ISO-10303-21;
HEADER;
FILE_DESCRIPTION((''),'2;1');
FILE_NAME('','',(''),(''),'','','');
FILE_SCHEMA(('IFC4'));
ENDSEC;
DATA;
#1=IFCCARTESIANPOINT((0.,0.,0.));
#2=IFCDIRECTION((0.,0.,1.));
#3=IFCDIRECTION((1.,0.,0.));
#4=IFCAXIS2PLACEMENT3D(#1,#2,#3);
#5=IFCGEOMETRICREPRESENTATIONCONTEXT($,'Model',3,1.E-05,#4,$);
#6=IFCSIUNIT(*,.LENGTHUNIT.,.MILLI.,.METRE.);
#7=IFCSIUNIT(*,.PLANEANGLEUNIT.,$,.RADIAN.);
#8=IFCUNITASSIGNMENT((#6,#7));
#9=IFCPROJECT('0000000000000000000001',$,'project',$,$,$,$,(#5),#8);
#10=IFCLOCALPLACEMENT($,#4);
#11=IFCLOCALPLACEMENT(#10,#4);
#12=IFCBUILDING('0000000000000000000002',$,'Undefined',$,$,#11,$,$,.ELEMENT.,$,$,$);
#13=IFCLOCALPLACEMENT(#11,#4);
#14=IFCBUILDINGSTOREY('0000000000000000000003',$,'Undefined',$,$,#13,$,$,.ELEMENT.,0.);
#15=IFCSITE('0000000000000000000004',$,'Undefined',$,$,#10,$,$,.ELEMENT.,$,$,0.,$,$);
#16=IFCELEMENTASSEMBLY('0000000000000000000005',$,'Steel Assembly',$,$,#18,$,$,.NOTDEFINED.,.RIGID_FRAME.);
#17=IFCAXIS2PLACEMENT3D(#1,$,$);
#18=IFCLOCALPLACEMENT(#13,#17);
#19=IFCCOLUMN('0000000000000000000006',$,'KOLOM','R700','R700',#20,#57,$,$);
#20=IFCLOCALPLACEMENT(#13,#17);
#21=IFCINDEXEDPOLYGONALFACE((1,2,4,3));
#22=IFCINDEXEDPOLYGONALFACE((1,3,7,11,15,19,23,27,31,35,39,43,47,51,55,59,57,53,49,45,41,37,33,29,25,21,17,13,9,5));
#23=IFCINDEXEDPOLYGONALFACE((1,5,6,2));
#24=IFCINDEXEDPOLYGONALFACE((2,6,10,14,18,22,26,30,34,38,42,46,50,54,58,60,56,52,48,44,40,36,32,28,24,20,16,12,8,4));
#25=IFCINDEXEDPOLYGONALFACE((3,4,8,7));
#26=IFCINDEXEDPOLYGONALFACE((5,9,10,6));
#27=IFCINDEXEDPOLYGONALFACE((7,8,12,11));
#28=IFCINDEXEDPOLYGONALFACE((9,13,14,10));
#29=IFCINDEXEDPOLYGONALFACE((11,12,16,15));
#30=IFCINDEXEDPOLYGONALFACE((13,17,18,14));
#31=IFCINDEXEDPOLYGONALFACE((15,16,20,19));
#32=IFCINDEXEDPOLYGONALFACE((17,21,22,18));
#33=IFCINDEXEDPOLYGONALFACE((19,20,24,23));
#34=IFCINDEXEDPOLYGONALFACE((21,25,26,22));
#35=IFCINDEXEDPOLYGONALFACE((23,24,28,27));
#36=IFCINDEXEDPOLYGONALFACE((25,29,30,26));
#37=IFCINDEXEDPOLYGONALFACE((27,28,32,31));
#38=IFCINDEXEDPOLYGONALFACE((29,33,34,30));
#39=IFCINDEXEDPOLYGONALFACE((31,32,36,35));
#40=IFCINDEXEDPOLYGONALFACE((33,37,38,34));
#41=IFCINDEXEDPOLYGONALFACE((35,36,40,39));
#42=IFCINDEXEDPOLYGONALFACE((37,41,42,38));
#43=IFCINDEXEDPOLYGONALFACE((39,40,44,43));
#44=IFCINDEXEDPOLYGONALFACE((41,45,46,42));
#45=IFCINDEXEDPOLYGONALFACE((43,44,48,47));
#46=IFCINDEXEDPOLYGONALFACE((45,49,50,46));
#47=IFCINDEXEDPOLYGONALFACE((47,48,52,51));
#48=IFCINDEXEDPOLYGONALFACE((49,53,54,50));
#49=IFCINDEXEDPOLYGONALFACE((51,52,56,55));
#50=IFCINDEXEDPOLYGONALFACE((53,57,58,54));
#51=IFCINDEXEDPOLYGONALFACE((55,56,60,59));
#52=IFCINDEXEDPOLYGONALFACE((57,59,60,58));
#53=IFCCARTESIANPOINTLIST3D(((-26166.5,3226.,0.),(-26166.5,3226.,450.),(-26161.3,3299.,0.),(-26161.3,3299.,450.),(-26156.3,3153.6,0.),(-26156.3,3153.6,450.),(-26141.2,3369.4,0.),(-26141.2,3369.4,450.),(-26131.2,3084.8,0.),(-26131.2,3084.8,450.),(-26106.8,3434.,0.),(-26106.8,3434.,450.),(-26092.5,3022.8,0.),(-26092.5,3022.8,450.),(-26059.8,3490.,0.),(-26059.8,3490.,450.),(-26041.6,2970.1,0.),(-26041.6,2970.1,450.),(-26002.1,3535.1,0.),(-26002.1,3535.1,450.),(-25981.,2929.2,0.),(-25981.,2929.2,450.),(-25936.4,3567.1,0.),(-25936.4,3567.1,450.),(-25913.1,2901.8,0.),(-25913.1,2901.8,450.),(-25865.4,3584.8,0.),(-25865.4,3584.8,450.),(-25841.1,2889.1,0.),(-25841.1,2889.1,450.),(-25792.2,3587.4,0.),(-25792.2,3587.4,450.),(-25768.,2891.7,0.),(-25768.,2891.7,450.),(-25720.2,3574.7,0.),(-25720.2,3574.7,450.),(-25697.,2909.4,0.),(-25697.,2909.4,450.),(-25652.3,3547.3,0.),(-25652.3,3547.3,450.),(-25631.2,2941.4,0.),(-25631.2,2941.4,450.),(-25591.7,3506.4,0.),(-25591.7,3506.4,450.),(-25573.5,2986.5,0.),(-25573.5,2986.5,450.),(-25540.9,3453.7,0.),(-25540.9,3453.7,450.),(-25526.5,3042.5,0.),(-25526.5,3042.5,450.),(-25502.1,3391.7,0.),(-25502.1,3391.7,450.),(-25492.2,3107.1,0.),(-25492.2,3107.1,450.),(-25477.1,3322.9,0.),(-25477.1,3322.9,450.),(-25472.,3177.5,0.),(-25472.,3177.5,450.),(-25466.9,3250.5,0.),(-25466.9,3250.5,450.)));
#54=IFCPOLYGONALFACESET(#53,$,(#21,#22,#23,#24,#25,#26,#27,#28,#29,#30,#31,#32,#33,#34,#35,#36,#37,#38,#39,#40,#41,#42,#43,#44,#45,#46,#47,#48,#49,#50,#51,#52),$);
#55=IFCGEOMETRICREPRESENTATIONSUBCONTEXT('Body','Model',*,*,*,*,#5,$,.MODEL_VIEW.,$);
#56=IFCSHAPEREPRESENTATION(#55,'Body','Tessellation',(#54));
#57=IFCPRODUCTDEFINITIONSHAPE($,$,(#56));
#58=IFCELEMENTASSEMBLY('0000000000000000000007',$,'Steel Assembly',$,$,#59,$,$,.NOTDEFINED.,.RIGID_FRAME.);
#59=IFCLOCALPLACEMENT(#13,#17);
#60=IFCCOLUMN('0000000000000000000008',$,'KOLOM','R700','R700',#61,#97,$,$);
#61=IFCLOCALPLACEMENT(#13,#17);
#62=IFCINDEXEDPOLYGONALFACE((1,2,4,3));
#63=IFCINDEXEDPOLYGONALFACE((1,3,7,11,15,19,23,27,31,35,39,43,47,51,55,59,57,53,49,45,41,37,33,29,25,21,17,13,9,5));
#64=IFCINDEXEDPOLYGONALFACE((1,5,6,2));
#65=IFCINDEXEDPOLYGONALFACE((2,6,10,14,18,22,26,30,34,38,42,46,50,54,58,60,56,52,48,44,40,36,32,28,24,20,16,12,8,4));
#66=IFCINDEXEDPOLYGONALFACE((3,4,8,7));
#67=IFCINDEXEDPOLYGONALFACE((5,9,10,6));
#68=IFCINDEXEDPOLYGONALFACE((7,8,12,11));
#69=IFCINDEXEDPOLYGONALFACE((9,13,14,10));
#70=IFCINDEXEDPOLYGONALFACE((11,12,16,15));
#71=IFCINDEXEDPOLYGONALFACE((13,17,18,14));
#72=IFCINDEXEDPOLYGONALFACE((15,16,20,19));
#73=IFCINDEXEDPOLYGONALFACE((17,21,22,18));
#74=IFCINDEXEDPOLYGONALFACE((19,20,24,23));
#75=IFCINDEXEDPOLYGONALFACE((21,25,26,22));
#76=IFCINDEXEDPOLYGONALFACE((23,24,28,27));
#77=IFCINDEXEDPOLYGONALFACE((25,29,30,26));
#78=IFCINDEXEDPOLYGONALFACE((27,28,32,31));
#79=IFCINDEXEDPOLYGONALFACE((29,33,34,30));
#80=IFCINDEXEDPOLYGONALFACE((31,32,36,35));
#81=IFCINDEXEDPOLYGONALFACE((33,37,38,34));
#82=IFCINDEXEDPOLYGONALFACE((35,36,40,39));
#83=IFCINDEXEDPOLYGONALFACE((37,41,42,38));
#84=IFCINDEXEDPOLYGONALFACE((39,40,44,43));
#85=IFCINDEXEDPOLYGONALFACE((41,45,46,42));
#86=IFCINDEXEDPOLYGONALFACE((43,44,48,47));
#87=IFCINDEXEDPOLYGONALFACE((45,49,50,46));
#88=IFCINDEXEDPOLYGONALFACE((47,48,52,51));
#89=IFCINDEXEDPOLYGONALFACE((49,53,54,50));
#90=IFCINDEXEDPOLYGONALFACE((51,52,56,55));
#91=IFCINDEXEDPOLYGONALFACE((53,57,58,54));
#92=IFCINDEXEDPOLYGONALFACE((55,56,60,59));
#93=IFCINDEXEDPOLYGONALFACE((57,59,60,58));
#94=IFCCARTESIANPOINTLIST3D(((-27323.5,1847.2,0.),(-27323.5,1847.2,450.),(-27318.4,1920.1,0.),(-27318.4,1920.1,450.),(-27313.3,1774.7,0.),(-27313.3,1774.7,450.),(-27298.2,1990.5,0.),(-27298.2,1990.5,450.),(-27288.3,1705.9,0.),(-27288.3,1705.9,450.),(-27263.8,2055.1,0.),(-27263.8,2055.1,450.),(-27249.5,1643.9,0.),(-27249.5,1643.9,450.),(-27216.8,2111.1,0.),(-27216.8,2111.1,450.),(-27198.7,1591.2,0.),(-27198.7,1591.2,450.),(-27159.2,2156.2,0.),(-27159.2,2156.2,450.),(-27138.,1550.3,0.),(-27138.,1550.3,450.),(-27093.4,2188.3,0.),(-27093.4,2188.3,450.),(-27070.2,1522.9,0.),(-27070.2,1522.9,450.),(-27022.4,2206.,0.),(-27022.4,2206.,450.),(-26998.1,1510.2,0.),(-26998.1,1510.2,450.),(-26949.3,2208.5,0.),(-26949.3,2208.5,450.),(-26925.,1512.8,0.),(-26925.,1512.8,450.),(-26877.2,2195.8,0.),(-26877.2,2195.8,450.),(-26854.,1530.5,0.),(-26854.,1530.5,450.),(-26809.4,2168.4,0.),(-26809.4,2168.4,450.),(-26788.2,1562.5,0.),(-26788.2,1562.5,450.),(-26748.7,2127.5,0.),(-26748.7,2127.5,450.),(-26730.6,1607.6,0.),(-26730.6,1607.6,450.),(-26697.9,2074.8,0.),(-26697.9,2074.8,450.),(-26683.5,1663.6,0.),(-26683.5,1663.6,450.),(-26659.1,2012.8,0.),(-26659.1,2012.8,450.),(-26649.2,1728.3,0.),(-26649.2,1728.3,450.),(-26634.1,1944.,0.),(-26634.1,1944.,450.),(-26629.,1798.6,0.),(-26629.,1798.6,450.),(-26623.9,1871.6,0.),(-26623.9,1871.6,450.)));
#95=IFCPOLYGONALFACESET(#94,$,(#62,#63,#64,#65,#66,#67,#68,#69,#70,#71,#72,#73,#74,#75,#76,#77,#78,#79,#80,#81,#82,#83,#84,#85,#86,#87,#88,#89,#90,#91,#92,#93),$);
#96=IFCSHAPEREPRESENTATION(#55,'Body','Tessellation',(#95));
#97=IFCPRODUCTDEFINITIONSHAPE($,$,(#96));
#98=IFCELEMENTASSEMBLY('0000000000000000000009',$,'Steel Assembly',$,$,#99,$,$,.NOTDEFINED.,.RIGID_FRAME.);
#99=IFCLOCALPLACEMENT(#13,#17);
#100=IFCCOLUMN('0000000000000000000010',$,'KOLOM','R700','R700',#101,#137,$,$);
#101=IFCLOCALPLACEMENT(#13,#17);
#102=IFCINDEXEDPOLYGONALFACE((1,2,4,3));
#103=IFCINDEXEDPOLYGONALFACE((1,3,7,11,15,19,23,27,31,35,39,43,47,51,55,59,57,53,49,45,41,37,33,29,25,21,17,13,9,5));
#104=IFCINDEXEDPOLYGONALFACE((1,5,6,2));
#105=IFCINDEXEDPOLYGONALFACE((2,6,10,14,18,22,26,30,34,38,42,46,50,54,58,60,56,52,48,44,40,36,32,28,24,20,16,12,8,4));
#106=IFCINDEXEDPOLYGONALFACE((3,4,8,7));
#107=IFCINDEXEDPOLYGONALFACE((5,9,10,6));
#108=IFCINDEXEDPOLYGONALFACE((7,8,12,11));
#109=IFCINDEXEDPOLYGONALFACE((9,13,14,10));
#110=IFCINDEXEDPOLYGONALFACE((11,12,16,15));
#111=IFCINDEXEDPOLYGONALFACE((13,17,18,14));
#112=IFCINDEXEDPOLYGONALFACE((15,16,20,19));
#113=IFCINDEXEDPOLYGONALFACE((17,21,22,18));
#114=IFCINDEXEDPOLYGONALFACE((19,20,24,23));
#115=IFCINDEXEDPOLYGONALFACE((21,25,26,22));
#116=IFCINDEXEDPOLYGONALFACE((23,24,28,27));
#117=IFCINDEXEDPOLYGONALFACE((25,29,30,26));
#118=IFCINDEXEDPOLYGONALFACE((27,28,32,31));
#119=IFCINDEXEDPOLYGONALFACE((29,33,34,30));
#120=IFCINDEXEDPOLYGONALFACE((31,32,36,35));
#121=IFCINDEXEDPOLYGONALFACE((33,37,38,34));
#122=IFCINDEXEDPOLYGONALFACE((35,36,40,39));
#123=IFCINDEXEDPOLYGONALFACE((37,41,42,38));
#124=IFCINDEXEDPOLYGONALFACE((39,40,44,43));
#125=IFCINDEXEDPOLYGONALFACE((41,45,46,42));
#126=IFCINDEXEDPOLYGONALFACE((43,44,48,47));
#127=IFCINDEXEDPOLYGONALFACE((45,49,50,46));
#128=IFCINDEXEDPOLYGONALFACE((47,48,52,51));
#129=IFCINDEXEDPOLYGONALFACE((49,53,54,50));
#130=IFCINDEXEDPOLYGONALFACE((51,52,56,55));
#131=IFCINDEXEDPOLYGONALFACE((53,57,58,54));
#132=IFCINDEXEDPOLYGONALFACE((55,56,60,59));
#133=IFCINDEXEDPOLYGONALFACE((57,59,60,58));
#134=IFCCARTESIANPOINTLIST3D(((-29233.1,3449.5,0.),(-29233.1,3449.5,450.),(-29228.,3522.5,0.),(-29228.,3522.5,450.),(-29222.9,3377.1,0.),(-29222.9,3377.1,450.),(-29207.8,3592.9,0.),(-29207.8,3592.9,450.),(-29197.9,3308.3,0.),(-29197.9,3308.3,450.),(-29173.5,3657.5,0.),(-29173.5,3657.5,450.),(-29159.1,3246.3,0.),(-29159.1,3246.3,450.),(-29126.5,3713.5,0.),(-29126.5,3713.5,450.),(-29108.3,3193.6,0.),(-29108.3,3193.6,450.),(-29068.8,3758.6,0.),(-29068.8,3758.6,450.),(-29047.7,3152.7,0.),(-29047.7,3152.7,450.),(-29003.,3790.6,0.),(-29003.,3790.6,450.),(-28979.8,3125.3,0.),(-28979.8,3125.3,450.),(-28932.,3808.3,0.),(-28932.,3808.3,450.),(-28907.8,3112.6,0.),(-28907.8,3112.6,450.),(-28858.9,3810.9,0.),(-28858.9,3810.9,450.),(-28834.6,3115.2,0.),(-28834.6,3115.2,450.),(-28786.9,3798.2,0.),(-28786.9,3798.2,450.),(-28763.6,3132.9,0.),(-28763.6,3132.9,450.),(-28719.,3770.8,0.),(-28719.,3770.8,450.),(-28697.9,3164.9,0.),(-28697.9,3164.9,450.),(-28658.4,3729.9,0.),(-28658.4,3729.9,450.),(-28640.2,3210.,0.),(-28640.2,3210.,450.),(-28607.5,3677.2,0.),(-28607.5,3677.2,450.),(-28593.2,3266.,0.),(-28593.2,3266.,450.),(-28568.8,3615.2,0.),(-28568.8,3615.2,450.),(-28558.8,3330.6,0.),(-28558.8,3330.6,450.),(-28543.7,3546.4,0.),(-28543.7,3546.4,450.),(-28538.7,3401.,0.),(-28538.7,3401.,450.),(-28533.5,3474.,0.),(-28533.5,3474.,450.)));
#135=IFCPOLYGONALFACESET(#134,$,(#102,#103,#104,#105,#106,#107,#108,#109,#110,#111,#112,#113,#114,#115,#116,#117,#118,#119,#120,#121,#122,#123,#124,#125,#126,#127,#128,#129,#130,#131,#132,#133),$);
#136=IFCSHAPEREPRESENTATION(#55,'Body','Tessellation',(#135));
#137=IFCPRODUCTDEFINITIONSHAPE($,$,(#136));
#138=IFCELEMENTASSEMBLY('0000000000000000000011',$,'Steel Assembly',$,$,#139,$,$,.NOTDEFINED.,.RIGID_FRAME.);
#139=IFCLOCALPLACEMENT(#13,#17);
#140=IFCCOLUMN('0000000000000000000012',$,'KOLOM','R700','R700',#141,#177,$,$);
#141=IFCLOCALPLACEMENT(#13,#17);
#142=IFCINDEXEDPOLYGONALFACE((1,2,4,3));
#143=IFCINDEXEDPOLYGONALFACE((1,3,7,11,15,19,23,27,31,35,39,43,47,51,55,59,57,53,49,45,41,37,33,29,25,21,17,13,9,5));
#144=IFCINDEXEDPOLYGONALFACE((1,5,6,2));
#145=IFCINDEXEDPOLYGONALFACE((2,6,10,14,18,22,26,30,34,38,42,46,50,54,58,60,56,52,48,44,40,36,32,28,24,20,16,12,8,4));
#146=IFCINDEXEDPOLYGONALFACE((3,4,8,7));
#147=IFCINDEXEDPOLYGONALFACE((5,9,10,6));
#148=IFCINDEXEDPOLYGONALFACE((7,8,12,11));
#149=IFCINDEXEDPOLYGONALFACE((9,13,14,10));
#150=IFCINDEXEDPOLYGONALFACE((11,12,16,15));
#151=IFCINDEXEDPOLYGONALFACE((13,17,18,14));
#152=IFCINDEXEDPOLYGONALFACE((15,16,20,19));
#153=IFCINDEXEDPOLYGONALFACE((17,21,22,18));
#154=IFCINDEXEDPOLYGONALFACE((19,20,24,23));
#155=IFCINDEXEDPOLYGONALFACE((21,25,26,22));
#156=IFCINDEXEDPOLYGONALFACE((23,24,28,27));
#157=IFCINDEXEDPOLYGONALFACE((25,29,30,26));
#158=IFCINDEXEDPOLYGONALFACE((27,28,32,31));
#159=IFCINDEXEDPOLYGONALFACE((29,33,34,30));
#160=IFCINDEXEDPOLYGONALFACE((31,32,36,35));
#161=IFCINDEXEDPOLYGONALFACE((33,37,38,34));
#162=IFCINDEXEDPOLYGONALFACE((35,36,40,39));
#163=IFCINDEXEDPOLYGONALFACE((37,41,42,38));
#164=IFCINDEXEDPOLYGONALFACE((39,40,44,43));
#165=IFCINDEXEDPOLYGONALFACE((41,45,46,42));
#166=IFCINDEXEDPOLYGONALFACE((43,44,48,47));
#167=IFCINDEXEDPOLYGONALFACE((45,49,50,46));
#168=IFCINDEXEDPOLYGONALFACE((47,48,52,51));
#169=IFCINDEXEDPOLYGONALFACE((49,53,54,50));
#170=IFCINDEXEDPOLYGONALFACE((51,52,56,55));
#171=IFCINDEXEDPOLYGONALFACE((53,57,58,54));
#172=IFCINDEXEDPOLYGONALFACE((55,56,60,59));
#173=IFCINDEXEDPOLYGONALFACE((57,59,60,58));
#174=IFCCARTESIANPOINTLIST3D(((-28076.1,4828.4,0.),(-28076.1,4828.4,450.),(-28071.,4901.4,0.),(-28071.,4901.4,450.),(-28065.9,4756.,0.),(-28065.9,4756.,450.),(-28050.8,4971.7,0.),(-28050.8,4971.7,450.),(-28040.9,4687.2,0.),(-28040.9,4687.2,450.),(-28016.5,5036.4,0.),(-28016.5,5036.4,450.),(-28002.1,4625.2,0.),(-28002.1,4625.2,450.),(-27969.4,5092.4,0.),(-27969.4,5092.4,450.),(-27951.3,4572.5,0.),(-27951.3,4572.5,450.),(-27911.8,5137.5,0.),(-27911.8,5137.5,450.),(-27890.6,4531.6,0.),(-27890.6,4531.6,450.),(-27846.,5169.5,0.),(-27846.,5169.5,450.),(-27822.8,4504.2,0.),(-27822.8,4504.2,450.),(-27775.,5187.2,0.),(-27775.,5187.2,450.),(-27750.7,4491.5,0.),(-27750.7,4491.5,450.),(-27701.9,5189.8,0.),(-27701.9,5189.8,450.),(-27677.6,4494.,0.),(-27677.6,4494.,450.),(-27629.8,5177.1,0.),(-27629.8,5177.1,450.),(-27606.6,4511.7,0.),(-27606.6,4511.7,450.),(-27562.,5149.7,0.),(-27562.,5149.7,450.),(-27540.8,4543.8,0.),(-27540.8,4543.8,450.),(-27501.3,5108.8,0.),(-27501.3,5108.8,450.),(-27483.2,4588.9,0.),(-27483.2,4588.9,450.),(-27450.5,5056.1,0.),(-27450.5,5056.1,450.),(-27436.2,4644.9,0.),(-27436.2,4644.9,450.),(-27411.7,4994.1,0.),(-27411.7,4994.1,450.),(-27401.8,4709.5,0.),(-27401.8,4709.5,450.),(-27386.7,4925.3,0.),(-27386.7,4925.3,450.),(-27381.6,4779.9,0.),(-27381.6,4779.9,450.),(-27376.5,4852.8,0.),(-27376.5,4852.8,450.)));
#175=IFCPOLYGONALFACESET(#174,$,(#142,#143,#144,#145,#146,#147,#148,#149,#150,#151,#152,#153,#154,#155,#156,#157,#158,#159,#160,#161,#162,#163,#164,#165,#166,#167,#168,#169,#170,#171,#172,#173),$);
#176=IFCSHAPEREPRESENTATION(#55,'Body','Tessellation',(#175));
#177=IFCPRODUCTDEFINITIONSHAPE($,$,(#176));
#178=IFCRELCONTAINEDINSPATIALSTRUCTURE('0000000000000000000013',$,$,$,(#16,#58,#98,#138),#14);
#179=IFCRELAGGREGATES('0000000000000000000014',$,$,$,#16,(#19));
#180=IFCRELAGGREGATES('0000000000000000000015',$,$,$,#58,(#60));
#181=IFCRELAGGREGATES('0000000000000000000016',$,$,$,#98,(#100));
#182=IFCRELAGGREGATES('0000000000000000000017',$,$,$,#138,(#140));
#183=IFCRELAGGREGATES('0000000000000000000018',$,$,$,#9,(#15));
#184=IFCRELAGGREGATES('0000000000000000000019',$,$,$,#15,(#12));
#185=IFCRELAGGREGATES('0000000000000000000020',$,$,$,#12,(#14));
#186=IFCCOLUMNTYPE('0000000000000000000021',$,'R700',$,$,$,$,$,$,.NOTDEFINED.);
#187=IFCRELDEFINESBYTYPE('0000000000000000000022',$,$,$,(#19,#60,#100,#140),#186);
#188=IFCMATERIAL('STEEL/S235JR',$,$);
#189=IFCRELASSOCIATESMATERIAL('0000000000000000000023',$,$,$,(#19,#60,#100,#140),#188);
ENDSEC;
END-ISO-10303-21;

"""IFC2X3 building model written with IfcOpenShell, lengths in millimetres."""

from ifc_helpers import new_model, si_unit, frame, origin_with_axes, origin_2d_with_axis, place, context, subcontext, project, spatial, circle, extrude, material, type_object, element, aggregate, save


model = new_model("IFC2X3")

# Units and contexts
model_context = context("Model", 3, precision=1e-05, world=origin_with_axes())
body_context = subcontext(model_context, "Body", "Model", "MODEL_VIEW")
ifc_project = project(units=[si_unit("LENGTHUNIT", "METRE", prefix="MILLI"), si_unit("PLANEANGLEUNIT", "RADIAN")], contexts=[model_context])

# Site, building, storey
site_placement = place(None, origin_with_axes())
site = spatial("IfcSite", under=ifc_project, at=site_placement, Name="Undefined", CompositionType="ELEMENT", RefElevation=0.0)
building_placement = place(site_placement, origin_with_axes())
building = spatial("IfcBuilding", under=site, at=building_placement, Name="Undefined", CompositionType="ELEMENT")
storey_placement = place(building_placement, origin_with_axes())
storey = spatial("IfcBuildingStorey", under=building, at=storey_placement, Name="Undefined", CompositionType="ELEMENT", Elevation=0.0)

# Element assemblies, columns
ifc_material = material(Name="STEEL/S235JR")
column_type = type_object("IfcColumnType", Name="R700", PredefinedType="NOTDEFINED")
assembly_1_placement = place(storey_placement, origin_with_axes())
assembly_1 = element("IfcElementAssembly", 1, at=assembly_1_placement, inside=storey, Name="Steel Assembly", AssemblyPlace="NOTDEFINED", PredefinedType="RIGID_FRAME")
column_1_placement = place(assembly_1_placement, frame((-25816.7, 3238.2, 450.0), z_axis=(0.0, 0.0, -1.0), x_axis=(0.766044, -0.642788, 0.0)))
column_1 = element("IfcColumn", 2, at=column_1_placement, type_object=column_type, material=ifc_material, Name="KOLOM", Description="R700", ObjectType="R700", context=body_context, shape_type="SweptSolid", body=[
    extrude(circle(Radius=350.0, at=origin_2d_with_axis()), frame((0.0, 0.0, 450.0), z_axis=(0.0, 0.0, -1.0), x_axis=(0.0, 1.0, 0.0)), (0.0, 0.0, 1.0), 450.0),
])
aggregate(assembly_1, [column_1])
assembly_2_placement = place(storey_placement, origin_with_axes())
assembly_2 = element("IfcElementAssembly", 3, at=assembly_2_placement, inside=storey, Name="Steel Assembly", AssemblyPlace="NOTDEFINED", PredefinedType="RIGID_FRAME")
column_2_placement = place(assembly_2_placement, frame((-26973.7, 1859.4, 450.0), z_axis=(0.0, 0.0, -1.0), x_axis=(0.766044, -0.642788, 0.0)))
column_2 = element("IfcColumn", 4, at=column_2_placement, type_object=column_type, material=ifc_material, Name="KOLOM", Description="R700", ObjectType="R700", context=body_context, shape_type="SweptSolid", body=[
    extrude(circle(Radius=350.0, at=origin_2d_with_axis()), frame((0.0, 0.0, 450.0), z_axis=(0.0, 0.0, -1.0), x_axis=(0.0, 1.0, 0.0)), (0.0, 0.0, 1.0), 450.0),
])
aggregate(assembly_2, [column_2])
assembly_3_placement = place(storey_placement, origin_with_axes())
assembly_3 = element("IfcElementAssembly", 5, at=assembly_3_placement, inside=storey, Name="Steel Assembly", AssemblyPlace="NOTDEFINED", PredefinedType="RIGID_FRAME")
column_3_placement = place(assembly_3_placement, frame((-28883.3, 3461.8, 450.0), z_axis=(0.0, 0.0, -1.0), x_axis=(-0.766044, 0.642788, 0.0)))
column_3 = element("IfcColumn", 6, at=column_3_placement, type_object=column_type, material=ifc_material, Name="KOLOM", Description="R700", ObjectType="R700", context=body_context, shape_type="SweptSolid", body=[
    extrude(circle(Radius=350.0, at=origin_2d_with_axis()), frame((0.0, 0.0, 450.0), z_axis=(0.0, 0.0, -1.0), x_axis=(0.0, 1.0, 0.0)), (0.0, 0.0, 1.0), 450.0),
])
aggregate(assembly_3, [column_3])
assembly_4_placement = place(storey_placement, origin_with_axes())
assembly_4 = element("IfcElementAssembly", 7, at=assembly_4_placement, inside=storey, Name="Steel Assembly", AssemblyPlace="NOTDEFINED", PredefinedType="RIGID_FRAME")
column_4_placement = place(assembly_4_placement, frame((-27726.3, 4840.6, 450.0), z_axis=(0.0, 0.0, -1.0), x_axis=(-0.766044, 0.642788, 0.0)))
column_4 = element("IfcColumn", 8, at=column_4_placement, type_object=column_type, material=ifc_material, Name="KOLOM", Description="R700", ObjectType="R700", context=body_context, shape_type="SweptSolid", body=[
    extrude(circle(Radius=350.0, at=origin_2d_with_axis()), frame((0.0, 0.0, 450.0), z_axis=(0.0, 0.0, -1.0), x_axis=(0.0, 1.0, 0.0)), (0.0, 0.0, 1.0), 450.0),
])
aggregate(assembly_4, [column_4])

save(model, "model.ifc")
